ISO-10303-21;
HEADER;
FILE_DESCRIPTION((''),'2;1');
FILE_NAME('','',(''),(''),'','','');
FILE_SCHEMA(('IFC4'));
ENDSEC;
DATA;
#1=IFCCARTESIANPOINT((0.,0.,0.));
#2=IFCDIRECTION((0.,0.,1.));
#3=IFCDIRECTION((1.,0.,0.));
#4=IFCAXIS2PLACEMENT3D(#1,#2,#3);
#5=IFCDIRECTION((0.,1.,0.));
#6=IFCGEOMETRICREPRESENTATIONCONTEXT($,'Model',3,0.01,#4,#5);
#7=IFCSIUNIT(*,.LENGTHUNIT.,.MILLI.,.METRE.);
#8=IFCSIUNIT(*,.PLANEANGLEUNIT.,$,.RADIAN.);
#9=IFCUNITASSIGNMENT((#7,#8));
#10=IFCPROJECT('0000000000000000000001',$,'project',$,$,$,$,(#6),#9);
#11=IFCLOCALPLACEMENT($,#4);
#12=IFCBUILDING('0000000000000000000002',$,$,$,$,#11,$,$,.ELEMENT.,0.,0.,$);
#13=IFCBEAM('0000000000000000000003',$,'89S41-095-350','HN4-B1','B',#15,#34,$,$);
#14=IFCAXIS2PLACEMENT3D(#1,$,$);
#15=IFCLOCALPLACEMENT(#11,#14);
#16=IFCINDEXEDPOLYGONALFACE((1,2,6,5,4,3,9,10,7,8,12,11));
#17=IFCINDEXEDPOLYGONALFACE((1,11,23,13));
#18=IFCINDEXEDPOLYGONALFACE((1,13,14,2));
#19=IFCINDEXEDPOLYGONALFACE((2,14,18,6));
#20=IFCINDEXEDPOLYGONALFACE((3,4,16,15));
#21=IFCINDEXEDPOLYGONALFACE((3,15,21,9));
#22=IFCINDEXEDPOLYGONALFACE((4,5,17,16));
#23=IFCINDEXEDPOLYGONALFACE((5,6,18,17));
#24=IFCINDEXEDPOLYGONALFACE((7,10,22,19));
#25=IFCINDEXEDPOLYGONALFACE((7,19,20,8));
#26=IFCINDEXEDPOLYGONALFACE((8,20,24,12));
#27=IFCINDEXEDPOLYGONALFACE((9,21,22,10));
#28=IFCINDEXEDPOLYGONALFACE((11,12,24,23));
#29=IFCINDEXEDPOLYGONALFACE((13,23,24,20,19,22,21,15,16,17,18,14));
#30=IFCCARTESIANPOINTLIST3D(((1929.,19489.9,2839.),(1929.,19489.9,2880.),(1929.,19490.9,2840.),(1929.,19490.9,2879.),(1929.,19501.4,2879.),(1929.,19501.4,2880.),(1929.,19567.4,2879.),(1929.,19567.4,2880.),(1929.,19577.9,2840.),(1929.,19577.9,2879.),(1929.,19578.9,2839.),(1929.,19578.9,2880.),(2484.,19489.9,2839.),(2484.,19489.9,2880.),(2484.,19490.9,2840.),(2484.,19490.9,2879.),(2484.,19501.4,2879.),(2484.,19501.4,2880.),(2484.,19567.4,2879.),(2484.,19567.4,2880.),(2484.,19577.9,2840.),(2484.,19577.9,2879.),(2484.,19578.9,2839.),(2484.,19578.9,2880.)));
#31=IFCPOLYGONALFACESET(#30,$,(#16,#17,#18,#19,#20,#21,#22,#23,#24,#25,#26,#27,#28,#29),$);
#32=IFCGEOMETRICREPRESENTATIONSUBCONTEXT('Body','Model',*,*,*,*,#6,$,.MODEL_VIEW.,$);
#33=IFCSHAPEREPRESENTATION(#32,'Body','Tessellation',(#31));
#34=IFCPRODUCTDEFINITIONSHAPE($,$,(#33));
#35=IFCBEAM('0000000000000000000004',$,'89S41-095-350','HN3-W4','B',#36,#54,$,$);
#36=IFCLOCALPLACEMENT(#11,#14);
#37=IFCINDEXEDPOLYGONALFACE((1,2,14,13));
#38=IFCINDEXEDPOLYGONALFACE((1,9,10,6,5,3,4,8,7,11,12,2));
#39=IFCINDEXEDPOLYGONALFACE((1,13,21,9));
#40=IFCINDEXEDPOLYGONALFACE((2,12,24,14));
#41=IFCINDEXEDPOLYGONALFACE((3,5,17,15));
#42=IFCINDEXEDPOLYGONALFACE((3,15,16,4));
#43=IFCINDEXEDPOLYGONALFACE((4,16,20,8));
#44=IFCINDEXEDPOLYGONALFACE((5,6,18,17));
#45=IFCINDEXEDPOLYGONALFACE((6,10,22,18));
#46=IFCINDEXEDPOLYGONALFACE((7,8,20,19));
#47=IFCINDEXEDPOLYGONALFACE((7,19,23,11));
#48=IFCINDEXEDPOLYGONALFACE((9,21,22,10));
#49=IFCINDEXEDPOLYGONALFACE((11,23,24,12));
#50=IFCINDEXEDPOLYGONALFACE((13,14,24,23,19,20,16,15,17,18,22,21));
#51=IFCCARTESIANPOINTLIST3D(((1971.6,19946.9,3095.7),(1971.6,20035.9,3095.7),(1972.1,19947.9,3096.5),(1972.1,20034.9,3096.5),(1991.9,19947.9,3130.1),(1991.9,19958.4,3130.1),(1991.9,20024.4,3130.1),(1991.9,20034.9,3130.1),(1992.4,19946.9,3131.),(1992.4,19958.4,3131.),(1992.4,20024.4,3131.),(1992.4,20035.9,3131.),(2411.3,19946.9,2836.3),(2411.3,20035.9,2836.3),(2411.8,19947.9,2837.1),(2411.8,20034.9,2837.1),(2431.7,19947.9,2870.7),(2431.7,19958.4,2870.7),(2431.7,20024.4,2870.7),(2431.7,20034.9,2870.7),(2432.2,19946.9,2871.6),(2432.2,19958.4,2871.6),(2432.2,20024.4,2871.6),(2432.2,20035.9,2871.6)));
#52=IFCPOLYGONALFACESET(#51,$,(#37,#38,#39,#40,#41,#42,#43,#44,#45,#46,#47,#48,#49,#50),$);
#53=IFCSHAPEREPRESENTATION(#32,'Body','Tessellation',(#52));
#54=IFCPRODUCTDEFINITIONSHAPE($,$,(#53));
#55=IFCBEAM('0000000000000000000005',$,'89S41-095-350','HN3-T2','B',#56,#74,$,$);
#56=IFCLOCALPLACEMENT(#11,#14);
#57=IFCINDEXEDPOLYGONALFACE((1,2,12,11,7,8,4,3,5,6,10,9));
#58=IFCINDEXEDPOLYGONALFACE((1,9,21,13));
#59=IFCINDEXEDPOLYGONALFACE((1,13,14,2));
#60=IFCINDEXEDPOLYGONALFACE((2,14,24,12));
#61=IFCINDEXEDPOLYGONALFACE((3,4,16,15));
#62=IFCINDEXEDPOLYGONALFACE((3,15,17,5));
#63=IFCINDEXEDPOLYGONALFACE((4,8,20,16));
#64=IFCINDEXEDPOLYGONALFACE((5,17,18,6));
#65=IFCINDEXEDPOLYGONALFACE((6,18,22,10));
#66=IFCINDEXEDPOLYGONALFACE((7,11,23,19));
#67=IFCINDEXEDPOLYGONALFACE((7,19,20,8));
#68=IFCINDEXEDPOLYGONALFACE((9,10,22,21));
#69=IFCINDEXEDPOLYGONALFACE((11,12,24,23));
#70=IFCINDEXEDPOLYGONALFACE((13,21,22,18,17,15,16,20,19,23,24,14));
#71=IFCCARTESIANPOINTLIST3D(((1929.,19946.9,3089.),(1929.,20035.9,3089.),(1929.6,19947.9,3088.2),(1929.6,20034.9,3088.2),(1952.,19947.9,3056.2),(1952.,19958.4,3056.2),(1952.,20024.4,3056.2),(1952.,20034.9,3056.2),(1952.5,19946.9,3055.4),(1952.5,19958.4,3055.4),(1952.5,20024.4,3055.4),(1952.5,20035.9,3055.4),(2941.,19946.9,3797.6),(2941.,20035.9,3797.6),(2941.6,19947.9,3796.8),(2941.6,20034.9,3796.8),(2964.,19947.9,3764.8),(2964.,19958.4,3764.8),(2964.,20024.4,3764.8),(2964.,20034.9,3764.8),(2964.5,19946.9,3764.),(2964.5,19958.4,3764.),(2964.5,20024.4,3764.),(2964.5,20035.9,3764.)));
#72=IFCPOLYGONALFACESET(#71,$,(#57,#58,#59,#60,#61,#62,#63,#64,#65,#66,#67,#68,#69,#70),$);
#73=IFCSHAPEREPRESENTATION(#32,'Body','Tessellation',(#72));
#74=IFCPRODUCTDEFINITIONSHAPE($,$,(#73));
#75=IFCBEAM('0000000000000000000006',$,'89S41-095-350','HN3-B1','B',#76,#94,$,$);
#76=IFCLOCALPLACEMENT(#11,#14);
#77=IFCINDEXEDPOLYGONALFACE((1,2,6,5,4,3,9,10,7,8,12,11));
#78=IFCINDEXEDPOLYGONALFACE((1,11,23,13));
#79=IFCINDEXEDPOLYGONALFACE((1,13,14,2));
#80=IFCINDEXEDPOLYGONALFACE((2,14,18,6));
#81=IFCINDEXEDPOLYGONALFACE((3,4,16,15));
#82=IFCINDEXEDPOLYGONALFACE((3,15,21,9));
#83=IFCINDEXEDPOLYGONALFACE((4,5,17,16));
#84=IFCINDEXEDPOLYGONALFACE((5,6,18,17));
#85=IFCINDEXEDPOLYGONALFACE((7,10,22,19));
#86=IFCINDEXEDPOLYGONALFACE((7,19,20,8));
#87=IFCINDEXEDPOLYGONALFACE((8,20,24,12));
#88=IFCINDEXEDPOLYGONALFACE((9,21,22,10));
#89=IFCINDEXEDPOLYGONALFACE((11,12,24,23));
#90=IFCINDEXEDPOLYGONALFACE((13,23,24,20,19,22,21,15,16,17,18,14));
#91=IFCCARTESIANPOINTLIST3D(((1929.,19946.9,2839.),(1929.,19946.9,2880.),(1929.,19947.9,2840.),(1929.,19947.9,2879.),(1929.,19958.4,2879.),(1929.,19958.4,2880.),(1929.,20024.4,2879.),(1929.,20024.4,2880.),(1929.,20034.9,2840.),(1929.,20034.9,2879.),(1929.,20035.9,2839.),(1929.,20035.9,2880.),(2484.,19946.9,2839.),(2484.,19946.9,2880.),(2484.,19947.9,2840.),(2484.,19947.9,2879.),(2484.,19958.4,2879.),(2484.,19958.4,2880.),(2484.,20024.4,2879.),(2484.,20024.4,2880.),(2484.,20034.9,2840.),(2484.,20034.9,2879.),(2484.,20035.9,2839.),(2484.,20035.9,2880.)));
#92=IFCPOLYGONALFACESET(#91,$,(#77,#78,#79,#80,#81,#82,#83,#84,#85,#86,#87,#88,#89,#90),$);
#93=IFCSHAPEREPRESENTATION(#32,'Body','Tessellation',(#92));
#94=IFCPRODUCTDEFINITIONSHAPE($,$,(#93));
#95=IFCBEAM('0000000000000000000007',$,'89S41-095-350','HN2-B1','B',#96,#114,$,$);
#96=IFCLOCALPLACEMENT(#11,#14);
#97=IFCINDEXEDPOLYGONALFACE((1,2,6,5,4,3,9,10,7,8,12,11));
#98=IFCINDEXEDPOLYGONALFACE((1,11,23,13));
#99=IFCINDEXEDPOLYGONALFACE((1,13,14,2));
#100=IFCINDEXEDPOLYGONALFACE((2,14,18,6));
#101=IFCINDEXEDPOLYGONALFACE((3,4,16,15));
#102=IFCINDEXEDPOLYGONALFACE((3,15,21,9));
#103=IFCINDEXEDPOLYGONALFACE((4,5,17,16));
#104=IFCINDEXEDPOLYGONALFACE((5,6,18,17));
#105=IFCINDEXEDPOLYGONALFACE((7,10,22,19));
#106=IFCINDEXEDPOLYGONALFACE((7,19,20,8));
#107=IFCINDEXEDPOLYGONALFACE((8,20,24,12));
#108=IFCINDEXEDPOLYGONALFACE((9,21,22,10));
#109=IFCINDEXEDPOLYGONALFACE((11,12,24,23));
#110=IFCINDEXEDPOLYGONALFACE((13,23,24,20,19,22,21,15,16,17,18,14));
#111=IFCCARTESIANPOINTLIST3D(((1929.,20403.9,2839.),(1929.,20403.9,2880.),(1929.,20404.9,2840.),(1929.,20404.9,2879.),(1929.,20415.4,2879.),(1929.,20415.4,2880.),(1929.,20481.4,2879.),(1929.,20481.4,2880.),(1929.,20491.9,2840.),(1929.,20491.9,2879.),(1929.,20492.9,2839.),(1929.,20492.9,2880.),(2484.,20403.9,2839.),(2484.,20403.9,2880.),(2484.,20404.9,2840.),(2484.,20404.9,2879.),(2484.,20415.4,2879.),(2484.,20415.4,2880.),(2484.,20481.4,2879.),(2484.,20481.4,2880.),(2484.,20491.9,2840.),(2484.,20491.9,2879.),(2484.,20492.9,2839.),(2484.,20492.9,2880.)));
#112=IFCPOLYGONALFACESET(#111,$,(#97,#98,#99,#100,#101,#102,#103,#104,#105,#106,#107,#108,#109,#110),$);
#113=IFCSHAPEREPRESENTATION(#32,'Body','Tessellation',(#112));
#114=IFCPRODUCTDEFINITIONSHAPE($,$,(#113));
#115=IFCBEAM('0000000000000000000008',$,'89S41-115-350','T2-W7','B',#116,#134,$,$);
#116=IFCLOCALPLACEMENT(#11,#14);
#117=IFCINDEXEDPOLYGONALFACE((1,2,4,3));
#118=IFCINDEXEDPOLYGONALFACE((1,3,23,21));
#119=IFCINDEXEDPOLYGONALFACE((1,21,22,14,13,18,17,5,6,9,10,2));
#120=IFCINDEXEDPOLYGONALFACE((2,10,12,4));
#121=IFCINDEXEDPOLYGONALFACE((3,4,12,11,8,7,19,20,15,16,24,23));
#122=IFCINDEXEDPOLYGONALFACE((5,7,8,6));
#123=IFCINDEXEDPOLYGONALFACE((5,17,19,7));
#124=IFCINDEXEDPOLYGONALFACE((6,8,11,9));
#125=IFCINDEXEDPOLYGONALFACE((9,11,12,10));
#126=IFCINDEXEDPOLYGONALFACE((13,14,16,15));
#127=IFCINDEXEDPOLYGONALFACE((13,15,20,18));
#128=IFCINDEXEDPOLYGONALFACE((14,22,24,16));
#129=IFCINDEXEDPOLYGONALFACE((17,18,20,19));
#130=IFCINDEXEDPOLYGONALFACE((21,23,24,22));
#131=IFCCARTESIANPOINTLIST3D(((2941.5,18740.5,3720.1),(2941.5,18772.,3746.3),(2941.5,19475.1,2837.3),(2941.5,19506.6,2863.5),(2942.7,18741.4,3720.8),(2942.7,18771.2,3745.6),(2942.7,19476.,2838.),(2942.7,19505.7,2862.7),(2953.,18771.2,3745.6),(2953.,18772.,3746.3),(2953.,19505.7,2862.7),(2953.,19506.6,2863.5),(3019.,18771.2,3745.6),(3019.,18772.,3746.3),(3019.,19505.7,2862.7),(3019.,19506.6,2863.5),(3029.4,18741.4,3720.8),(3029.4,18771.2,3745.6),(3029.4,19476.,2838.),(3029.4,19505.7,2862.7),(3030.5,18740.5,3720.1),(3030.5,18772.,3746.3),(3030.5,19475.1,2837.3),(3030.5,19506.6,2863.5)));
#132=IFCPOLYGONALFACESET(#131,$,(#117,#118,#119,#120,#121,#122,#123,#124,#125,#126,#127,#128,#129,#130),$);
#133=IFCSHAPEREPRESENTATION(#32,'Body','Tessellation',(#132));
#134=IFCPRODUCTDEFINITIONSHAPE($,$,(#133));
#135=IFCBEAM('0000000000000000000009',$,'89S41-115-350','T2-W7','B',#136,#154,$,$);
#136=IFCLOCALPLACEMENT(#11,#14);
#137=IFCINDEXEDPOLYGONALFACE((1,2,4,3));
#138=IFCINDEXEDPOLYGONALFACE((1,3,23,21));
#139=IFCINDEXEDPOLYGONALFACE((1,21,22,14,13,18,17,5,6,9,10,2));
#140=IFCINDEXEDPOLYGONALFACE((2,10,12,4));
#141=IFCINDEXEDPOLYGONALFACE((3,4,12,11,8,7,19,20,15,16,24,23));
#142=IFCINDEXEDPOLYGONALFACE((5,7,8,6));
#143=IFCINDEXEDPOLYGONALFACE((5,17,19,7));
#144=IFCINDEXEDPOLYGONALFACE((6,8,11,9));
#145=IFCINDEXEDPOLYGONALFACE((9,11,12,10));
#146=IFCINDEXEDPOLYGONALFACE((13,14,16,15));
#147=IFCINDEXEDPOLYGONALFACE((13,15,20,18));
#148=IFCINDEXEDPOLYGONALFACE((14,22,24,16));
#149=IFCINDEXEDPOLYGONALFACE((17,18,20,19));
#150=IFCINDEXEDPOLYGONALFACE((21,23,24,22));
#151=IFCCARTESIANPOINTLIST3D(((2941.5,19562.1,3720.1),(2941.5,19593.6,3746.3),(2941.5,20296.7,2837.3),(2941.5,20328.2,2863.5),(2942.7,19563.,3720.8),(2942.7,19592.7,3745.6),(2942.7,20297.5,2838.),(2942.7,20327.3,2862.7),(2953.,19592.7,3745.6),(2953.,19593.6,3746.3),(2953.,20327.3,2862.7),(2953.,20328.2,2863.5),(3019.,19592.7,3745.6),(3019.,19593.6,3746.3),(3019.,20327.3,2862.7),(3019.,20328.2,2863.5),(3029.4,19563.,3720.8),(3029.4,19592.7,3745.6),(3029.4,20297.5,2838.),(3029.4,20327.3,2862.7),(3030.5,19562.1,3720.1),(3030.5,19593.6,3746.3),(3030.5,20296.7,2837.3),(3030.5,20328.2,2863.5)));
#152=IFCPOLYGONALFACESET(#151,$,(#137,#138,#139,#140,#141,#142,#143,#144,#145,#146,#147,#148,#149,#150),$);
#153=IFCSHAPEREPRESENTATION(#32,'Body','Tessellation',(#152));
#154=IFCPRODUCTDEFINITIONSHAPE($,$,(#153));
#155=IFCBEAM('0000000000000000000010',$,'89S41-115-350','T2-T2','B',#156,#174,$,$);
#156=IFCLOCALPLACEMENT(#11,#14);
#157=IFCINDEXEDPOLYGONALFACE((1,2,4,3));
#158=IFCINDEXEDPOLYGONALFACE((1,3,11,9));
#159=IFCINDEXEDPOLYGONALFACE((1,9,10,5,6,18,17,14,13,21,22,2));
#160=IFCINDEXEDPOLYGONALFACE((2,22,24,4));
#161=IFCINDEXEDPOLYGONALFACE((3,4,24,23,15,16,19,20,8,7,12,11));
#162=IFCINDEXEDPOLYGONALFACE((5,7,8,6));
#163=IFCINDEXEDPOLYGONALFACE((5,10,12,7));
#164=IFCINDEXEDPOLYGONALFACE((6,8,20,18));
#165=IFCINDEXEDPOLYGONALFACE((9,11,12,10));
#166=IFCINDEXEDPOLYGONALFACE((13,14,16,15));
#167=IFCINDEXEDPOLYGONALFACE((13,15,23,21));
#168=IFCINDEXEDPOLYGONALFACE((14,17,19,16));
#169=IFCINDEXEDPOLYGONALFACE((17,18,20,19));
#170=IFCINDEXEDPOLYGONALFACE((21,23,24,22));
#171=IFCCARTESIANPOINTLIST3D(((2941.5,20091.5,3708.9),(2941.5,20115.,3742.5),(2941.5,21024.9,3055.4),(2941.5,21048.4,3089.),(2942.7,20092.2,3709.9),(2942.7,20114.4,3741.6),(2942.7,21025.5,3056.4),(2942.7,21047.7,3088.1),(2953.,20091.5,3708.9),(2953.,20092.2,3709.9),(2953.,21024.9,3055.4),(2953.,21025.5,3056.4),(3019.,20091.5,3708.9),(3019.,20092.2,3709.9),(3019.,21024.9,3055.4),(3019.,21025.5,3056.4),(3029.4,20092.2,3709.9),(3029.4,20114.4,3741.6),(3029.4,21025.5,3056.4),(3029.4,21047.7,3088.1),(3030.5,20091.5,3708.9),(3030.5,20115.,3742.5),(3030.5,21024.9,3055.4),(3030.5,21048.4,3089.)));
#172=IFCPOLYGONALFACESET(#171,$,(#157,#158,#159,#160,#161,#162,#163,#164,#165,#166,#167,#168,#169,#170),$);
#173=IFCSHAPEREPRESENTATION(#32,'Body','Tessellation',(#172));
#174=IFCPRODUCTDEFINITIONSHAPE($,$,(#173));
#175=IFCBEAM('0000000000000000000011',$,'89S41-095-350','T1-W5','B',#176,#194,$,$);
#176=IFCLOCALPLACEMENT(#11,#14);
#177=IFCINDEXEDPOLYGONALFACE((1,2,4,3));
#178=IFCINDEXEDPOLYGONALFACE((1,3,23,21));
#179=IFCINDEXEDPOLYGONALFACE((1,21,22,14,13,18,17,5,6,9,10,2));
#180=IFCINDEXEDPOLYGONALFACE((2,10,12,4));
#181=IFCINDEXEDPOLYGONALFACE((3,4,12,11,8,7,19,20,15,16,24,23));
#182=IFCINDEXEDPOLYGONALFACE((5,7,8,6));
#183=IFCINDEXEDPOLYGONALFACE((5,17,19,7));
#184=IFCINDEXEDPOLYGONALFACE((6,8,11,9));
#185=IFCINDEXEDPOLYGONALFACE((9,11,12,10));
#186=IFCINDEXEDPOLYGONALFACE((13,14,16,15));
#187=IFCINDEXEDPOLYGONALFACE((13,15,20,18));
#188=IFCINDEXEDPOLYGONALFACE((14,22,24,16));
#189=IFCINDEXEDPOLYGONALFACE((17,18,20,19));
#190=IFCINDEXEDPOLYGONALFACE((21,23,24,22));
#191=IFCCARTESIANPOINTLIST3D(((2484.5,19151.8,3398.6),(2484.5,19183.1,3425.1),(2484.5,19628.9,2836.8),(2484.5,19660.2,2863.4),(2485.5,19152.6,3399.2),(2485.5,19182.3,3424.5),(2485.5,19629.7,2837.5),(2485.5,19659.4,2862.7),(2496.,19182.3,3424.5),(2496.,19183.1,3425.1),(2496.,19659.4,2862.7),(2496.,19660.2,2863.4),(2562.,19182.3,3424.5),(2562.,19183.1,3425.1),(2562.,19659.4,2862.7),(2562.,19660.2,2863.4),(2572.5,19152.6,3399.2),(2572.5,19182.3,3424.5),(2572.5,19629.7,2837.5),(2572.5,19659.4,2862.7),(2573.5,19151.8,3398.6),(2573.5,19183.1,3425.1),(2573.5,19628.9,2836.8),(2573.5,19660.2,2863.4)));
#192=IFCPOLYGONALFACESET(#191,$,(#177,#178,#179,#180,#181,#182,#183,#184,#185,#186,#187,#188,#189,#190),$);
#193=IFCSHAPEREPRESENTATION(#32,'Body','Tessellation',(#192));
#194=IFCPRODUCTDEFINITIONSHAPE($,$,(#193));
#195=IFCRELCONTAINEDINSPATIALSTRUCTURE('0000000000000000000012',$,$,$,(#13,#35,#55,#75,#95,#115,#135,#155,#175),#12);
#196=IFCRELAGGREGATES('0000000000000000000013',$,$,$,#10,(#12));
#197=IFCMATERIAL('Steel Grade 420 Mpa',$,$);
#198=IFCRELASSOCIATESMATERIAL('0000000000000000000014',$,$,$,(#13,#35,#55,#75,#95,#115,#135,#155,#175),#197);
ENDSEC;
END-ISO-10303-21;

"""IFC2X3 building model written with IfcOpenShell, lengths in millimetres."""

from ifc_helpers import new_model, si_unit, direction, frame, origin, origin_with_axes, origin_2d_with_axis, place, context, subcontext, project, spatial, c_section, extrude, source, transform, mapped, material, element, save


model = new_model("IFC2X3")

# Units and contexts
model_context = context("Model", 3, precision=0.01, world=origin_with_axes(), true_north=direction((0.0, 1.0, 0.0)))
body_context = subcontext(model_context, "Body", "Model", "MODEL_VIEW")
ifc_project = project(units=[si_unit("LENGTHUNIT", "METRE", prefix="MILLI"), si_unit("PLANEANGLEUNIT", "RADIAN")], contexts=[model_context])

# Building
building_placement = place(None, origin_with_axes())
building = spatial("IfcBuilding", under=ifc_project, at=building_placement, CompositionType="ELEMENT", ElevationOfRefHeight=0.0, ElevationOfTerrain=0.0)

# Shared definitions
ifc_material = material(Name="Steel Grade 420 Mpa")

# Beams
shared_shape_1 = source(origin(), body_context, "Body", "SweptSolid", [
    extrude(c_section(Depth=89.0, Width=41.0, WallThickness=1.0, Girth=11.5, at=origin_2d_with_axis()), origin_with_axes(), (0.0, 0.0, 1.0), 555.0),
])
beam_1_placement = place(None, frame((1929.0, 19534.4, 2859.5), z_axis=(1.0, 0.0, 0.0), x_axis=(0.0, 0.0, 1.0)))
element("IfcBeam", 1, at=beam_1_placement, inside=building, material=ifc_material, Name="89S41-095-350", Description="HN4-B1", ObjectType="B", context=body_context, shape_type="MappedRepresentation", body=[
    mapped(shared_shape_1, transform((0.0, 0.0, 0.0), scale=1.0)),
])
shared_shape_2 = source(origin(), body_context, "Body", "SweptSolid", [
    extrude(c_section(Depth=89.0, Width=41.0, WallThickness=1.0, Girth=11.5, at=origin_2d_with_axis()), origin_with_axes(), (0.0, 0.0, 1.0), 510.5),
])
beam_2_placement = place(None, frame((1982.0, 19991.4, 3113.3), z_axis=(0.861295, 0.0, -0.508104), x_axis=(0.508104, 0.0, 0.861295)))
element("IfcBeam", 2, at=beam_2_placement, inside=building, material=ifc_material, Name="89S41-095-350", Description="HN3-W4", ObjectType="B", context=body_context, shape_type="MappedRepresentation", body=[
    mapped(shared_shape_2, transform((0.0, 0.0, 0.0), scale=1.0)),
])
shared_shape_3 = source(origin(), body_context, "Body", "SweptSolid", [
    extrude(c_section(Depth=89.0, Width=41.0, WallThickness=1.0, Girth=11.5, at=origin_2d_with_axis()), origin_with_axes(), (0.0, 0.0, 1.0), 1235.4),
])
beam_3_placement = place(None, frame((2952.8, 19991.4, 3780.8), z_axis=(-0.819152, 0.0, -0.573576), x_axis=(0.573576, 0.0, -0.819152)))
element("IfcBeam", 3, at=beam_3_placement, inside=building, material=ifc_material, Name="89S41-095-350", Description="HN3-T2", ObjectType="B", context=body_context, shape_type="MappedRepresentation", body=[
    mapped(shared_shape_3, transform((0.0, 0.0, 0.0), scale=1.0)),
])
shared_shape_4 = source(origin(), body_context, "Body", "SweptSolid", [
    extrude(c_section(Depth=89.0, Width=41.0, WallThickness=1.0, Girth=11.5, at=origin_2d_with_axis()), origin_with_axes(), (0.0, 0.0, 1.0), 555.0),
])
beam_4_placement = place(None, frame((1929.0, 19991.4, 2859.5), z_axis=(1.0, 0.0, 0.0), x_axis=(0.0, 0.0, 1.0)))
element("IfcBeam", 4, at=beam_4_placement, inside=building, material=ifc_material, Name="89S41-095-350", Description="HN3-B1", ObjectType="B", context=body_context, shape_type="MappedRepresentation", body=[
    mapped(shared_shape_4, transform((0.0, 0.0, 0.0), scale=1.0)),
])
shared_shape_5 = source(origin(), body_context, "Body", "SweptSolid", [
    extrude(c_section(Depth=89.0, Width=41.0, WallThickness=1.0, Girth=11.5, at=origin_2d_with_axis()), origin_with_axes(), (0.0, 0.0, 1.0), 555.0),
])
beam_5_placement = place(None, frame((1929.0, 20448.4, 2859.5), z_axis=(1.0, 0.0, 0.0), x_axis=(0.0, 0.0, 1.0)))
element("IfcBeam", 5, at=beam_5_placement, inside=building, material=ifc_material, Name="89S41-095-350", Description="HN2-B1", ObjectType="B", context=body_context, shape_type="MappedRepresentation", body=[
    mapped(shared_shape_5, transform((0.0, 0.0, 0.0), scale=1.0)),
])
shared_shape_6 = source(origin(), body_context, "Body", "SweptSolid", [
    extrude(c_section(Depth=89.0, Width=41.0, WallThickness=1.1, Girth=11.5, at=origin_2d_with_axis()), origin_with_axes(), (0.0, 0.0, 1.0), 1148.5),
])
beam_6_placement = place(None, frame((2986.0, 19490.8, 2850.4), z_axis=(0.0, -0.639598, 0.768709), x_axis=(0.0, 0.768709, 0.639598)))
element("IfcBeam", 6, at=beam_6_placement, inside=building, material=ifc_material, Name="89S41-115-350", Description="T2-W7", ObjectType="B", context=body_context, shape_type="MappedRepresentation", body=[
    mapped(shared_shape_6, transform((0.0, 0.0, 0.0), scale=1.0)),
])
shared_shape_7 = source(origin(), body_context, "Body", "SweptSolid", [
    extrude(c_section(Depth=89.0, Width=41.0, WallThickness=1.1, Girth=11.5, at=origin_2d_with_axis()), origin_with_axes(), (0.0, 0.0, 1.0), 1148.5),
])
beam_7_placement = place(None, frame((2986.0, 20312.4, 2850.4), z_axis=(0.0, -0.639598, 0.768709), x_axis=(0.0, 0.768709, 0.639598)))
element("IfcBeam", 7, at=beam_7_placement, inside=building, material=ifc_material, Name="89S41-115-350", Description="T2-W7", ObjectType="B", context=body_context, shape_type="MappedRepresentation", body=[
    mapped(shared_shape_7, transform((0.0, 0.0, 0.0), scale=1.0)),
])
shared_shape_8 = source(origin(), body_context, "Body", "SweptSolid", [
    extrude(c_section(Depth=89.0, Width=41.0, WallThickness=1.1, Girth=11.5, at=origin_2d_with_axis()), origin_with_axes(), (0.0, 0.0, 1.0), 1139.4),
])
beam_8_placement = place(None, frame((2986.0, 20103.3, 3725.7), z_axis=(0.0, 0.819152, -0.573576), x_axis=(0.0, -0.573576, -0.819152)))
element("IfcBeam", 8, at=beam_8_placement, inside=building, material=ifc_material, Name="89S41-115-350", Description="T2-T2", ObjectType="B", context=body_context, shape_type="MappedRepresentation", body=[
    mapped(shared_shape_8, transform((0.0, 0.0, 0.0), scale=1.0)),
])
shared_shape_9 = source(origin(), body_context, "Body", "SweptSolid", [
    extrude(c_section(Depth=89.0, Width=41.0, WallThickness=1.0, Girth=11.5, at=origin_2d_with_axis()), origin_with_axes(), (0.0, 0.0, 1.0), 737.0),
])
beam_9_placement = place(None, frame((2529.0, 19644.6, 2850.1), z_axis=(0.0, -0.647361, 0.762183), x_axis=(0.0, 0.762183, 0.647361)))
element("IfcBeam", 9, at=beam_9_placement, inside=building, material=ifc_material, Name="89S41-095-350", Description="T1-W5", ObjectType="B", context=body_context, shape_type="MappedRepresentation", body=[
    mapped(shared_shape_9, transform((0.0, 0.0, 0.0), scale=1.0)),
])

save(model, "model.ifc")
